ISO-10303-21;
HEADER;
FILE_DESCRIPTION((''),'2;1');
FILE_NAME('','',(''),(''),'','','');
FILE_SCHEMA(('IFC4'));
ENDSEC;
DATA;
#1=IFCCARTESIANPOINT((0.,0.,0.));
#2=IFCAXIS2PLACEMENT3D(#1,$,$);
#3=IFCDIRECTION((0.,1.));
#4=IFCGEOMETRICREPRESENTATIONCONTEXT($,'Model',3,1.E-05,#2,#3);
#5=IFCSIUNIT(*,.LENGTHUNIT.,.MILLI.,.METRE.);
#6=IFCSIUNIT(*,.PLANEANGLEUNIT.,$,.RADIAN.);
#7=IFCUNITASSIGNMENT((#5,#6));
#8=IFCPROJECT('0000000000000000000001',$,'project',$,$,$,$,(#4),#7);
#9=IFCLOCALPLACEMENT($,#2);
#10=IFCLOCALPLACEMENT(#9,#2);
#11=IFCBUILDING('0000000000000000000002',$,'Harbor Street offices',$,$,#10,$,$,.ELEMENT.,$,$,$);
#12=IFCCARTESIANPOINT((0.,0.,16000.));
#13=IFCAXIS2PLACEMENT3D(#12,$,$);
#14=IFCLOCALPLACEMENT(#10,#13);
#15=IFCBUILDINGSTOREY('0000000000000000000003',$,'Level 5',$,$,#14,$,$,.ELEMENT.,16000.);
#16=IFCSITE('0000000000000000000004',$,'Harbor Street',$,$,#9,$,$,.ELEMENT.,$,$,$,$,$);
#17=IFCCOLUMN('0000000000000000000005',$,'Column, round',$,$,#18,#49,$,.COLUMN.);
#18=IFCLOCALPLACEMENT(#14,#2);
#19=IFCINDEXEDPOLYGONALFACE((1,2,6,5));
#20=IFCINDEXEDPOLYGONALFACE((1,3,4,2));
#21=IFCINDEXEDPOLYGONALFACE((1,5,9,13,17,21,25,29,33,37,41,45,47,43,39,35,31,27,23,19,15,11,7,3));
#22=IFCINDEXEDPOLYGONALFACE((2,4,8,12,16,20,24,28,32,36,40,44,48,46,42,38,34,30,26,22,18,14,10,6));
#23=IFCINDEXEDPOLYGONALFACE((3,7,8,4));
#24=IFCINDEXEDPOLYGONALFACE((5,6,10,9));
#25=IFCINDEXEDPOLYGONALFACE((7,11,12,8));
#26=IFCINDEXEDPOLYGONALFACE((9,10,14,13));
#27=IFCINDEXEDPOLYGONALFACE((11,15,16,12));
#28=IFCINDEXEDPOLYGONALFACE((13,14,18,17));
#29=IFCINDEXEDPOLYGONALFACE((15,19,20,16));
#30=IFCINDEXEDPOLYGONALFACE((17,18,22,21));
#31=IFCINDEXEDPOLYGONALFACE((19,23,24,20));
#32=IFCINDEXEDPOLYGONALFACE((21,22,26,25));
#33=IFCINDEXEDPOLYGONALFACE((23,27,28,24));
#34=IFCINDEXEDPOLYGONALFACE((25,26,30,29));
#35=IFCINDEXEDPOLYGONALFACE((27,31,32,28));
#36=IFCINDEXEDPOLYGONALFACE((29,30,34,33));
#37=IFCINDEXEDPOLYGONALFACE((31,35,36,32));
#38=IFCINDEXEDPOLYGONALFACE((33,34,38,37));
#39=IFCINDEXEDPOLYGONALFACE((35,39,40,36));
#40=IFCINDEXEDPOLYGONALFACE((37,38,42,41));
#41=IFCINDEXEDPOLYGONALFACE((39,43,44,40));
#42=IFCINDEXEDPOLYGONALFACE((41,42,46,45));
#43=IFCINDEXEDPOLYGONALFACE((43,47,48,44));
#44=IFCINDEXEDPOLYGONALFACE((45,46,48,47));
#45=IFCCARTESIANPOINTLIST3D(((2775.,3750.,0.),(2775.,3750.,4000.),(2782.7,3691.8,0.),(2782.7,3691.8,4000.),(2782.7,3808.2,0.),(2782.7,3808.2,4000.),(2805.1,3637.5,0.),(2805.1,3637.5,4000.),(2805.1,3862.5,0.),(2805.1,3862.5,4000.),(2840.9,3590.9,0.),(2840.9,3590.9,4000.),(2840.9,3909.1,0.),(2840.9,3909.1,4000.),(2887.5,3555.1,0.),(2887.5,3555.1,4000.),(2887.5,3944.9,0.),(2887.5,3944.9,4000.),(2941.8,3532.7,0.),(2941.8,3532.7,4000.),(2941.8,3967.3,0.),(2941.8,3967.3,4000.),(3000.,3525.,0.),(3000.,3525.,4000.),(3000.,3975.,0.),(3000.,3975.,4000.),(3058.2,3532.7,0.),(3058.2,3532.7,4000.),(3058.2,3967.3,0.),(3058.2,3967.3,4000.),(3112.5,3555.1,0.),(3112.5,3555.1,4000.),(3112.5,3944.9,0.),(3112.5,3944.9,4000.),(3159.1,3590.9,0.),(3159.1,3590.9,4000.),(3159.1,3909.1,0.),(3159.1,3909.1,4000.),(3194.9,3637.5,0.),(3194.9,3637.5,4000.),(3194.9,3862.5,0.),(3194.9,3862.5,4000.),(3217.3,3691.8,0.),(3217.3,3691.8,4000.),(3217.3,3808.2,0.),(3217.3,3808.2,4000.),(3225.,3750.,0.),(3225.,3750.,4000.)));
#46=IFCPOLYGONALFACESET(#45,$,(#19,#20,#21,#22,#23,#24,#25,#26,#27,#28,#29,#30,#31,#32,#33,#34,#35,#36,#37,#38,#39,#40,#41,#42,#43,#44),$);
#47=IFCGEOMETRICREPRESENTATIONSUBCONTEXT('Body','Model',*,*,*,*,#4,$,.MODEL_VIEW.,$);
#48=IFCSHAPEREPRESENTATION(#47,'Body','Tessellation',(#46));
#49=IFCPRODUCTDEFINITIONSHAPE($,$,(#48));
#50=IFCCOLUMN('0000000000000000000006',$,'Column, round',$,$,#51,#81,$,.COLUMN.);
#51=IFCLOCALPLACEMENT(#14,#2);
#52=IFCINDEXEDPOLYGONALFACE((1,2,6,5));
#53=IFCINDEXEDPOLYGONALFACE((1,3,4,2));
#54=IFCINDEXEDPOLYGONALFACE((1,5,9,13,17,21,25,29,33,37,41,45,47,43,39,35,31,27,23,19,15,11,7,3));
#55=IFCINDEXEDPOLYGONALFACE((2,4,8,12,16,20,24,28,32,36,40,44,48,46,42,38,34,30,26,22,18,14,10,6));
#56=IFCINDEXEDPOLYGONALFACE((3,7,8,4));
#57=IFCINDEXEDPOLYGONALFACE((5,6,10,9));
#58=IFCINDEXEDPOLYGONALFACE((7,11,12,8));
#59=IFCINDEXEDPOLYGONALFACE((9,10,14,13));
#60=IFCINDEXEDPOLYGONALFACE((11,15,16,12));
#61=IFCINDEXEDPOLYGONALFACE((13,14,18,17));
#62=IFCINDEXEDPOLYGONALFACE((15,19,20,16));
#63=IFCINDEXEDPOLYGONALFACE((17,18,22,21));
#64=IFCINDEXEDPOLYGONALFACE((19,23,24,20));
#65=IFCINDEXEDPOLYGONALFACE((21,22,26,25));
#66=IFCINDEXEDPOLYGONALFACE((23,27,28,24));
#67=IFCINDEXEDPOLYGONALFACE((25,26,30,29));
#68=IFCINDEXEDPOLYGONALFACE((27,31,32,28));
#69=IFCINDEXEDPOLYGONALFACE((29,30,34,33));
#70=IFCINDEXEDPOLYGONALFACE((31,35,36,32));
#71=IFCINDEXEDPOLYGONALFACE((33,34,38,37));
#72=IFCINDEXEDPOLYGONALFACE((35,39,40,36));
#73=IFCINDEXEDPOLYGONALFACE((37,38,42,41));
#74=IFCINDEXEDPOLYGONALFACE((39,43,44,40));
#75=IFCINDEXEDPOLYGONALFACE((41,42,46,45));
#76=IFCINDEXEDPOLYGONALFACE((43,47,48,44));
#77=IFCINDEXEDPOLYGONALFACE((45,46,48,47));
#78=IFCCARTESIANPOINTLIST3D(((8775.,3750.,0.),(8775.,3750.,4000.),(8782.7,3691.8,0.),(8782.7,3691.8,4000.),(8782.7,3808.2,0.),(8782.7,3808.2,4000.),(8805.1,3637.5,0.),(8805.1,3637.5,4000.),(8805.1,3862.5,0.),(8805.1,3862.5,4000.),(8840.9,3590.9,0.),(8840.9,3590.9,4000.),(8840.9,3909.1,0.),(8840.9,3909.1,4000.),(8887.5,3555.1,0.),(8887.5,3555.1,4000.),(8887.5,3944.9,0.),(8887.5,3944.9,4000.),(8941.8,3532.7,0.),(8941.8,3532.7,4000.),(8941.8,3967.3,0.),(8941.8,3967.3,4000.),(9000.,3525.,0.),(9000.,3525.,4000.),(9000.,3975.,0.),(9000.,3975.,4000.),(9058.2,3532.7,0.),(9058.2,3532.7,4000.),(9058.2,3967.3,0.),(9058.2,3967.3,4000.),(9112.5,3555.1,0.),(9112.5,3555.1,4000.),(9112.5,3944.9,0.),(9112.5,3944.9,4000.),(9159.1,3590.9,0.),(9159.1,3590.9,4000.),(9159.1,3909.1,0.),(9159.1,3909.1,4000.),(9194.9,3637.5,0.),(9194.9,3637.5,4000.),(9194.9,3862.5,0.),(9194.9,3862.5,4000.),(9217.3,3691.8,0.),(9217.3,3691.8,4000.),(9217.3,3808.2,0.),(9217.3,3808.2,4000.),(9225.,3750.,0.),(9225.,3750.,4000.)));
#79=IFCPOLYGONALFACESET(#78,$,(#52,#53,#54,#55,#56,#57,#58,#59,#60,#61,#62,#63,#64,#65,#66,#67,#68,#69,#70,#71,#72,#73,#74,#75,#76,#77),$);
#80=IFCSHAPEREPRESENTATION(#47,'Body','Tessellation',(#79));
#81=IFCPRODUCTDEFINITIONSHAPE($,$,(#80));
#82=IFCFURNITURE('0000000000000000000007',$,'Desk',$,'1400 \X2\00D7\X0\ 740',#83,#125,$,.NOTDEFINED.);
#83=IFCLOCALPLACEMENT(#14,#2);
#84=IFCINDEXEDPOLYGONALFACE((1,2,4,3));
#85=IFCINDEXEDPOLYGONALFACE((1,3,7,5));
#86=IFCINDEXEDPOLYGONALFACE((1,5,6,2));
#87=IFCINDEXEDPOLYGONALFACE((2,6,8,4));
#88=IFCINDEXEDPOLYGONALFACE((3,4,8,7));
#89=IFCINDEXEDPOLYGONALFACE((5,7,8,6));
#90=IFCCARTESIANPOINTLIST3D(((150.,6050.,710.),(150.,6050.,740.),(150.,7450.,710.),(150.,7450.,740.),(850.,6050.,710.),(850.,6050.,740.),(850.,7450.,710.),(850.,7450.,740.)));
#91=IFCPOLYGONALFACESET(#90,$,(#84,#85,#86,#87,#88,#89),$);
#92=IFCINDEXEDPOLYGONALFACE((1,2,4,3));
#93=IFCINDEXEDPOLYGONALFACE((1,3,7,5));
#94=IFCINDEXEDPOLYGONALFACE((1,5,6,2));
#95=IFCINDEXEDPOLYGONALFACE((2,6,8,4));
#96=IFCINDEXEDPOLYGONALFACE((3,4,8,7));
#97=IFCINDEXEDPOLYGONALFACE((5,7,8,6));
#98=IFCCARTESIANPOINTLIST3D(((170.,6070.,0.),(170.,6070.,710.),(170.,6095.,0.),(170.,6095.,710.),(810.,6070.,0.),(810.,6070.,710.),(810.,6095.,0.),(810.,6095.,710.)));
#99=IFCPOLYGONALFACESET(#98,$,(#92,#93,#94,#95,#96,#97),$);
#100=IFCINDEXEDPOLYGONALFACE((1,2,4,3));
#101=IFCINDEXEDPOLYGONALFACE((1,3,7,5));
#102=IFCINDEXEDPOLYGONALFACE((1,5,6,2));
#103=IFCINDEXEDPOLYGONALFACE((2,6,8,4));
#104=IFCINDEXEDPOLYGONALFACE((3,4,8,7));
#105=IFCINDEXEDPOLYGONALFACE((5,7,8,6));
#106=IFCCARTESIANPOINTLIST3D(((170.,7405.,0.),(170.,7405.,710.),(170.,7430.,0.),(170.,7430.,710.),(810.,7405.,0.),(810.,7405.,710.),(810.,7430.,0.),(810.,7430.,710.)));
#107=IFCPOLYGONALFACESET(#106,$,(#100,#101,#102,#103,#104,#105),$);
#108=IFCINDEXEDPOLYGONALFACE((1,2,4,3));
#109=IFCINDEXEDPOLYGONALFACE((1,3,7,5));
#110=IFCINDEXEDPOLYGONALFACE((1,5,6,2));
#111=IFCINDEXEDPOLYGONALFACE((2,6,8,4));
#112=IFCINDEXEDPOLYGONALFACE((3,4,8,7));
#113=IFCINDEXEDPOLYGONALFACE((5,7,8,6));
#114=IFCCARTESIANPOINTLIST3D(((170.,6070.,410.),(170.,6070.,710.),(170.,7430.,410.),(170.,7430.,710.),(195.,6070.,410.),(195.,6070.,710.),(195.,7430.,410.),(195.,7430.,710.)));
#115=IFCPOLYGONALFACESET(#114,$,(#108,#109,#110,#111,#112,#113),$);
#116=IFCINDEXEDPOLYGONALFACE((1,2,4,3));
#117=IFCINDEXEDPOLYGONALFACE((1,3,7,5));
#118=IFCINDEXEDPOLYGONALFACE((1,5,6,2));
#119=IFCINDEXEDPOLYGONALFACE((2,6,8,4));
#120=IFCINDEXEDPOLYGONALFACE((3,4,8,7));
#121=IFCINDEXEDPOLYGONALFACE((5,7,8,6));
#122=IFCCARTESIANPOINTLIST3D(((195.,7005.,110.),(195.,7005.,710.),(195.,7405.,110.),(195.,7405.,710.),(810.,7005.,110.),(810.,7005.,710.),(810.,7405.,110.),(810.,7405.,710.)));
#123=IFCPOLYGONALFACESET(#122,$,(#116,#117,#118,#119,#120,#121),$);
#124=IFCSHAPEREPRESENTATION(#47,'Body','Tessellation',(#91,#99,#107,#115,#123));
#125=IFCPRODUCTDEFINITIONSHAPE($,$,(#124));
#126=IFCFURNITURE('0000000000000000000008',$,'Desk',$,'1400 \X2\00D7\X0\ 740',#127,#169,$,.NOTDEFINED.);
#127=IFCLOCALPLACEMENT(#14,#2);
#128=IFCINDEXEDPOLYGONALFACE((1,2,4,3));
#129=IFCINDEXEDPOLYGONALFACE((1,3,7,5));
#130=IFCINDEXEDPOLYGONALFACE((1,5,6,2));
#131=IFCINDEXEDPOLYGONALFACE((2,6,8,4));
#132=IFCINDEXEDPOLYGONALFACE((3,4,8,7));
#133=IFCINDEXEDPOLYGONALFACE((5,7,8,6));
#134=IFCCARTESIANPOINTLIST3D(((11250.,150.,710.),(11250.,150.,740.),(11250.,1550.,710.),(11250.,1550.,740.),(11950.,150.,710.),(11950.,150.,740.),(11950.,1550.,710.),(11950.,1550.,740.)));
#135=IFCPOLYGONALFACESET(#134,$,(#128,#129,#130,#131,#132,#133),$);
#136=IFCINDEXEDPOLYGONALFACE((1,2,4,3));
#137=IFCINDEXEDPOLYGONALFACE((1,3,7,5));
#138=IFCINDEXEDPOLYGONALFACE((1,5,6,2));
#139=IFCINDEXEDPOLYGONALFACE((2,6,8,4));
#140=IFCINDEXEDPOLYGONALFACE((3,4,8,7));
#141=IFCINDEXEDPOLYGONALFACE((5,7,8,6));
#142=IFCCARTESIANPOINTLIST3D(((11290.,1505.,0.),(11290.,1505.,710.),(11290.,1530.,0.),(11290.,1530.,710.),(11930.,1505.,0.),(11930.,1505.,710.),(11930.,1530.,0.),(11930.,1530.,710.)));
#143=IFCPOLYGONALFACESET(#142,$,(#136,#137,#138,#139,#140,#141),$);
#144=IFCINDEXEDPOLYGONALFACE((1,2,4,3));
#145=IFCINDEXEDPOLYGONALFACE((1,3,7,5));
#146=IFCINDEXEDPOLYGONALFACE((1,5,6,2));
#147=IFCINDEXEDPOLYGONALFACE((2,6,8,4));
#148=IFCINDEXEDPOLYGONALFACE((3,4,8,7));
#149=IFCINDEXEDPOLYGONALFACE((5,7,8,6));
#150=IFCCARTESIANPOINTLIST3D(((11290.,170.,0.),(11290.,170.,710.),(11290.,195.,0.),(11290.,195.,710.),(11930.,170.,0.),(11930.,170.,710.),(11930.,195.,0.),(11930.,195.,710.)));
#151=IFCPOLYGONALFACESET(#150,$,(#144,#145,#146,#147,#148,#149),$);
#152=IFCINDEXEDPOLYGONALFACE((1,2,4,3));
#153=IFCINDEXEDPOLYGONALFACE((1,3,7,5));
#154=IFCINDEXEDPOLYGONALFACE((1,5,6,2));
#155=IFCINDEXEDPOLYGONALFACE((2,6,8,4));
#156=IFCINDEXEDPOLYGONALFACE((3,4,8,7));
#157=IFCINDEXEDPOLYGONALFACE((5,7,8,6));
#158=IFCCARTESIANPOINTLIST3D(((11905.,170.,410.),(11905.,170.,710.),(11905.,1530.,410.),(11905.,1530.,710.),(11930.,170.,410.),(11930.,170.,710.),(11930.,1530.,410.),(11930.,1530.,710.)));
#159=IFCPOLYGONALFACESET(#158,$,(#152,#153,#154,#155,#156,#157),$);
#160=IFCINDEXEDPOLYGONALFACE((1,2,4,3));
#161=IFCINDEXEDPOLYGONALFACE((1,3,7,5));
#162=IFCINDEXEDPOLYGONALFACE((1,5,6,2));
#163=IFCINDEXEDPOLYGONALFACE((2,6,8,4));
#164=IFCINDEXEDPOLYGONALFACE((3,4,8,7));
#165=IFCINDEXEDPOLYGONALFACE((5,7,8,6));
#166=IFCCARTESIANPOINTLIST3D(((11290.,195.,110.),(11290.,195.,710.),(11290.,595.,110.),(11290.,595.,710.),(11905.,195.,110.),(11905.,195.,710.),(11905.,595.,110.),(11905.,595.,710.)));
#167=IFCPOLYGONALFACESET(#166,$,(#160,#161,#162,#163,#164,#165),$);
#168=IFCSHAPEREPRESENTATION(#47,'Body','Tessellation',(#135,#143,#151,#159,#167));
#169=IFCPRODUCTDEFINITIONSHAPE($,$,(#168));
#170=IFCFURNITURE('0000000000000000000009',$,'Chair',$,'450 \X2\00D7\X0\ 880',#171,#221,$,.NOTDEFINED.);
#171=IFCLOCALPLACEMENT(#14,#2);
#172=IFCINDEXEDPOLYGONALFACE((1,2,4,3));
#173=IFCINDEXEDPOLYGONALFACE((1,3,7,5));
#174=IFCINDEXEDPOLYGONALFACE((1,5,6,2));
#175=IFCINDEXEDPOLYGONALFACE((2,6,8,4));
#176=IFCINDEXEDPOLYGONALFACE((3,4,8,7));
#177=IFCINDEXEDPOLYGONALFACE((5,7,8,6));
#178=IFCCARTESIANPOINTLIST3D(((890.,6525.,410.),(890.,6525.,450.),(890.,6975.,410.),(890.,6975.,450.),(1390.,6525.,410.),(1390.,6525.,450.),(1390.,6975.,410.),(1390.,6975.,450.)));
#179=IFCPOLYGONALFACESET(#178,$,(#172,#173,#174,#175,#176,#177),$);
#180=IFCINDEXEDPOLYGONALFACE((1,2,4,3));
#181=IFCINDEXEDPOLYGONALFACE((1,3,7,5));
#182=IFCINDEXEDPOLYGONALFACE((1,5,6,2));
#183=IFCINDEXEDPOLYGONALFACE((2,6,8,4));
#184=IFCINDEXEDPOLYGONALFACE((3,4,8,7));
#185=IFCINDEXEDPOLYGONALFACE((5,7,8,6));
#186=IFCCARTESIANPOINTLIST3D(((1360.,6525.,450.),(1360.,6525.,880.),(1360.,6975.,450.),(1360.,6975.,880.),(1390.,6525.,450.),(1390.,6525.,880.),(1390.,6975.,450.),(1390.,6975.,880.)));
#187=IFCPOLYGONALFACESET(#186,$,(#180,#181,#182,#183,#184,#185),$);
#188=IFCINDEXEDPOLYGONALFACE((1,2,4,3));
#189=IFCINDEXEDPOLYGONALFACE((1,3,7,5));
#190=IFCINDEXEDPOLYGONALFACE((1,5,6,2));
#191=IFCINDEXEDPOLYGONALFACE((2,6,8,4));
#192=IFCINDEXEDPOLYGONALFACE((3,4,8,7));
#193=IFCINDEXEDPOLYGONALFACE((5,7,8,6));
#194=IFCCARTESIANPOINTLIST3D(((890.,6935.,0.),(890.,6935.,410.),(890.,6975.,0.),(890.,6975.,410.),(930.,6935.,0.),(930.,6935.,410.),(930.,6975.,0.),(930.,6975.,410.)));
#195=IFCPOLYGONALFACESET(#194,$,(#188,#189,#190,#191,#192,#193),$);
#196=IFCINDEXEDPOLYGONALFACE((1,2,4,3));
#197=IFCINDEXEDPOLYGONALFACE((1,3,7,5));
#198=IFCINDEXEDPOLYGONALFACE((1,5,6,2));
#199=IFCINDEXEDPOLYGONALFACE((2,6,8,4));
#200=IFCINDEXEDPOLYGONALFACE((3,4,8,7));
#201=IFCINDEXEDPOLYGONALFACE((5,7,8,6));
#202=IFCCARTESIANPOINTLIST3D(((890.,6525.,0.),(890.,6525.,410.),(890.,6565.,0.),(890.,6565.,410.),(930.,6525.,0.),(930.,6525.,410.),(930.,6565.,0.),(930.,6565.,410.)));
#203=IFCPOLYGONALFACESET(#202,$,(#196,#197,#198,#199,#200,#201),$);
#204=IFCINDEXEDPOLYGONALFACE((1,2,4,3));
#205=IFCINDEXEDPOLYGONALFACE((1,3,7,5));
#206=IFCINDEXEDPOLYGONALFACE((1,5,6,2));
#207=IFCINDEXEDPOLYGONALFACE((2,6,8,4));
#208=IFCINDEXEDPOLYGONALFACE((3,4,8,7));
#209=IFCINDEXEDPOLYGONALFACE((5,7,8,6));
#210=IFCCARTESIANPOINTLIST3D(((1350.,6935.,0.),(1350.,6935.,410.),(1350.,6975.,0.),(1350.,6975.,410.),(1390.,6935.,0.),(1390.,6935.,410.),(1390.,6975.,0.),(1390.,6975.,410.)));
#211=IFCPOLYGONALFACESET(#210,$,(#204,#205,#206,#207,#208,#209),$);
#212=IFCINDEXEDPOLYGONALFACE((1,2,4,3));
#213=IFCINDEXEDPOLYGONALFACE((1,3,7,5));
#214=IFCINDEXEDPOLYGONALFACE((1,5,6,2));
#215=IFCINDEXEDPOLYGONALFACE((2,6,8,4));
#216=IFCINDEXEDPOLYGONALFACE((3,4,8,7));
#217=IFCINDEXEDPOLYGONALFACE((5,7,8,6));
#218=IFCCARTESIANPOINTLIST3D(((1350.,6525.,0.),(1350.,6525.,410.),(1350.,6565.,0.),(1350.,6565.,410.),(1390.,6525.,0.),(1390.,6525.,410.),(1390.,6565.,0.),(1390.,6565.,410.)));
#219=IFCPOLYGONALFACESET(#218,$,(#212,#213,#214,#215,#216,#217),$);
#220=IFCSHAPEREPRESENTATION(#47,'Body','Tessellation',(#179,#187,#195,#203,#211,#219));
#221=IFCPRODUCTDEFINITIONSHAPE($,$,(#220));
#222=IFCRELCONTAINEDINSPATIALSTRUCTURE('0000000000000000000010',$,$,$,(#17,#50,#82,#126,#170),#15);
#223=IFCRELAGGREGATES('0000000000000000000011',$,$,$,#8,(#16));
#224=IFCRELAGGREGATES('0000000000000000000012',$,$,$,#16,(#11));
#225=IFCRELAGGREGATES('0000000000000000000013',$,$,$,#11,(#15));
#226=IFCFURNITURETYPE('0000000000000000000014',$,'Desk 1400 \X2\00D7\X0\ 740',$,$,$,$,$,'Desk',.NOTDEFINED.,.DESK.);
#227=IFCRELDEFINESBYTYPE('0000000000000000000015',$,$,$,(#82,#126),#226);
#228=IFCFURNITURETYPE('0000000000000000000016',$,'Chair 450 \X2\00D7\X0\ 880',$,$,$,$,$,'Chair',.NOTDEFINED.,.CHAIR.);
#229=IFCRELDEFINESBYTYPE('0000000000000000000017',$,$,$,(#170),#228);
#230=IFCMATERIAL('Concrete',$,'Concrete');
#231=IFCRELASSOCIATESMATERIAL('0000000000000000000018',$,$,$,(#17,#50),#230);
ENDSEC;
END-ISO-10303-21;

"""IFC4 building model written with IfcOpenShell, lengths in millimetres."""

from ifc_helpers import new_model, si_unit, direction, frame, origin, origin_2d, place, context, subcontext, project, spatial, polyline, circle, outline, extrude, source, transform, mapped, material, type_object, type_shapes, element, save


model = new_model("IFC4")

# Units and contexts
model_context = context("Model", 3, precision=1e-05, world=origin(), true_north=direction((0.0, 1.0)))
body_context = subcontext(model_context, "Body", "Model", "MODEL_VIEW")
ifc_project = project(units=[si_unit("LENGTHUNIT", "METRE", prefix="MILLI"), si_unit("PLANEANGLEUNIT", "RADIAN")], contexts=[model_context])

# Site, building, storey
site_placement = place(None, origin())
site = spatial("IfcSite", under=ifc_project, at=site_placement, Name="Harbor Street", CompositionType="ELEMENT")
building_placement = place(site_placement, origin())
building = spatial("IfcBuilding", under=site, at=building_placement, Name="Harbor Street offices", CompositionType="ELEMENT")
storey_placement = place(building_placement, frame((0.0, 0.0, 16000.0)))
storey = spatial("IfcBuildingStorey", under=building, at=storey_placement, Name="Level 5", CompositionType="ELEMENT", Elevation=16000.0)

# Columns
ifc_material = material(Name="Concrete", Category="Concrete")
for number, where, z_axis, x_axis, name in (
    (1, (3000.0, 3750.0, 0.0), (0.0, 0.0, 1.0), (1.0, 0.0, 0.0), "Column, round"),
    (2, (9000.0, 3750.0, 0.0), (0.0, 0.0, 1.0), (1.0, 0.0, 0.0), "Column, round"),
):
    element("IfcColumn", number, at=place(storey_placement, frame(where, z_axis=z_axis, x_axis=x_axis)), inside=storey, material=ifc_material, Name=name, PredefinedType="COLUMN", context=body_context, shape_type="SweptSolid", body=[
        extrude(circle(Radius=225.0, at=origin_2d()), origin(), (0.0, 0.0, 1.0), 4000.0),
    ])

# Furniture
furniture_type_1 = type_object("IfcFurnitureType", Name="Desk 1400 × 740", ElementType="Desk", AssemblyPlace="NOTDEFINED", PredefinedType="DESK")
shared_shape_1 = source(origin(), body_context, "Body", "SweptSolid", [
    extrude(outline(polyline([(-700.0, 0.0), (700.0, 0.0), (700.0, 700.0), (-700.0, 700.0), (-700.0, 0.0)])), frame((0.0, 0.0, 710.0)), (0.0, 0.0, 1.0), 30.0),
    extrude(outline(polyline([(-680.0, 40.0), (-655.0, 40.0), (-655.0, 680.0), (-680.0, 680.0), (-680.0, 40.0)])), origin(), (0.0, 0.0, 1.0), 710.0),
    extrude(outline(polyline([(655.0, 40.0), (680.0, 40.0), (680.0, 680.0), (655.0, 680.0), (655.0, 40.0)])), origin(), (0.0, 0.0, 1.0), 710.0),
    extrude(outline(polyline([(-680.0, 655.0), (680.0, 655.0), (680.0, 680.0), (-680.0, 680.0), (-680.0, 655.0)])), frame((0.0, 0.0, 410.0)), (0.0, 0.0, 1.0), 300.0),
    extrude(outline(polyline([(255.0, 40.0), (655.0, 40.0), (655.0, 655.0), (255.0, 655.0), (255.0, 40.0)])), frame((0.0, 0.0, 110.0)), (0.0, 0.0, 1.0), 600.0),
])
type_shapes(furniture_type_1, [shared_shape_1])
for number, where, z_axis, x_axis, name in (
    (3, (850.0, 6750.0, 0.0), (0.0, 0.0, 1.0), (0.0, 1.0, 0.0), "Desk"),
    (4, (11250.0, 850.0, 0.0), (0.0, 0.0, 1.0), (0.0, -1.0, 0.0), "Desk"),
):
    element("IfcFurniture", number, at=place(storey_placement, frame(where, z_axis=z_axis, x_axis=x_axis)), inside=storey, type_object=furniture_type_1, Name=name, ObjectType="1400 × 740", PredefinedType="NOTDEFINED", context=body_context, shape_type="MappedRepresentation", body=[
        mapped(shared_shape_1, transform((0.0, 0.0, 0.0))),
    ])
furniture_type_2 = type_object("IfcFurnitureType", Name="Chair 450 × 880", ElementType="Chair", AssemblyPlace="NOTDEFINED", PredefinedType="CHAIR")
shared_shape_2 = source(origin(), body_context, "Body", "SweptSolid", [
    extrude(outline(polyline([(-225.0, 0.0), (225.0, 0.0), (225.0, 500.0), (-225.0, 500.0), (-225.0, 0.0)])), frame((0.0, 0.0, 410.0)), (0.0, 0.0, 1.0), 40.0),
    extrude(outline(polyline([(-225.0, 470.0), (225.0, 470.0), (225.0, 500.0), (-225.0, 500.0), (-225.0, 470.0)])), frame((0.0, 0.0, 450.0)), (0.0, 0.0, 1.0), 430.0),
    extrude(outline(polyline([(-225.0, 0.0), (-185.0, 0.0), (-185.0, 40.0), (-225.0, 40.0), (-225.0, 0.0)])), origin(), (0.0, 0.0, 1.0), 410.0),
    extrude(outline(polyline([(185.0, 0.0), (225.0, 0.0), (225.0, 40.0), (185.0, 40.0), (185.0, 0.0)])), origin(), (0.0, 0.0, 1.0), 410.0),
    extrude(outline(polyline([(-225.0, 460.0), (-185.0, 460.0), (-185.0, 500.0), (-225.0, 500.0), (-225.0, 460.0)])), origin(), (0.0, 0.0, 1.0), 410.0),
    extrude(outline(polyline([(185.0, 460.0), (225.0, 460.0), (225.0, 500.0), (185.0, 500.0), (185.0, 460.0)])), origin(), (0.0, 0.0, 1.0), 410.0),
])
type_shapes(furniture_type_2, [shared_shape_2])
for number, where, z_axis, x_axis, name in (
    (5, (890.0, 6750.0, 0.0), (0.0, 0.0, 1.0), (0.0, -1.0, 0.0), "Chair"),
):
    element("IfcFurniture", number, at=place(storey_placement, frame(where, z_axis=z_axis, x_axis=x_axis)), inside=storey, type_object=furniture_type_2, Name=name, ObjectType="450 × 880", PredefinedType="NOTDEFINED", context=body_context, shape_type="MappedRepresentation", body=[
        mapped(shared_shape_2, transform((0.0, 0.0, 0.0))),
    ])

save(model, "model.ifc")
